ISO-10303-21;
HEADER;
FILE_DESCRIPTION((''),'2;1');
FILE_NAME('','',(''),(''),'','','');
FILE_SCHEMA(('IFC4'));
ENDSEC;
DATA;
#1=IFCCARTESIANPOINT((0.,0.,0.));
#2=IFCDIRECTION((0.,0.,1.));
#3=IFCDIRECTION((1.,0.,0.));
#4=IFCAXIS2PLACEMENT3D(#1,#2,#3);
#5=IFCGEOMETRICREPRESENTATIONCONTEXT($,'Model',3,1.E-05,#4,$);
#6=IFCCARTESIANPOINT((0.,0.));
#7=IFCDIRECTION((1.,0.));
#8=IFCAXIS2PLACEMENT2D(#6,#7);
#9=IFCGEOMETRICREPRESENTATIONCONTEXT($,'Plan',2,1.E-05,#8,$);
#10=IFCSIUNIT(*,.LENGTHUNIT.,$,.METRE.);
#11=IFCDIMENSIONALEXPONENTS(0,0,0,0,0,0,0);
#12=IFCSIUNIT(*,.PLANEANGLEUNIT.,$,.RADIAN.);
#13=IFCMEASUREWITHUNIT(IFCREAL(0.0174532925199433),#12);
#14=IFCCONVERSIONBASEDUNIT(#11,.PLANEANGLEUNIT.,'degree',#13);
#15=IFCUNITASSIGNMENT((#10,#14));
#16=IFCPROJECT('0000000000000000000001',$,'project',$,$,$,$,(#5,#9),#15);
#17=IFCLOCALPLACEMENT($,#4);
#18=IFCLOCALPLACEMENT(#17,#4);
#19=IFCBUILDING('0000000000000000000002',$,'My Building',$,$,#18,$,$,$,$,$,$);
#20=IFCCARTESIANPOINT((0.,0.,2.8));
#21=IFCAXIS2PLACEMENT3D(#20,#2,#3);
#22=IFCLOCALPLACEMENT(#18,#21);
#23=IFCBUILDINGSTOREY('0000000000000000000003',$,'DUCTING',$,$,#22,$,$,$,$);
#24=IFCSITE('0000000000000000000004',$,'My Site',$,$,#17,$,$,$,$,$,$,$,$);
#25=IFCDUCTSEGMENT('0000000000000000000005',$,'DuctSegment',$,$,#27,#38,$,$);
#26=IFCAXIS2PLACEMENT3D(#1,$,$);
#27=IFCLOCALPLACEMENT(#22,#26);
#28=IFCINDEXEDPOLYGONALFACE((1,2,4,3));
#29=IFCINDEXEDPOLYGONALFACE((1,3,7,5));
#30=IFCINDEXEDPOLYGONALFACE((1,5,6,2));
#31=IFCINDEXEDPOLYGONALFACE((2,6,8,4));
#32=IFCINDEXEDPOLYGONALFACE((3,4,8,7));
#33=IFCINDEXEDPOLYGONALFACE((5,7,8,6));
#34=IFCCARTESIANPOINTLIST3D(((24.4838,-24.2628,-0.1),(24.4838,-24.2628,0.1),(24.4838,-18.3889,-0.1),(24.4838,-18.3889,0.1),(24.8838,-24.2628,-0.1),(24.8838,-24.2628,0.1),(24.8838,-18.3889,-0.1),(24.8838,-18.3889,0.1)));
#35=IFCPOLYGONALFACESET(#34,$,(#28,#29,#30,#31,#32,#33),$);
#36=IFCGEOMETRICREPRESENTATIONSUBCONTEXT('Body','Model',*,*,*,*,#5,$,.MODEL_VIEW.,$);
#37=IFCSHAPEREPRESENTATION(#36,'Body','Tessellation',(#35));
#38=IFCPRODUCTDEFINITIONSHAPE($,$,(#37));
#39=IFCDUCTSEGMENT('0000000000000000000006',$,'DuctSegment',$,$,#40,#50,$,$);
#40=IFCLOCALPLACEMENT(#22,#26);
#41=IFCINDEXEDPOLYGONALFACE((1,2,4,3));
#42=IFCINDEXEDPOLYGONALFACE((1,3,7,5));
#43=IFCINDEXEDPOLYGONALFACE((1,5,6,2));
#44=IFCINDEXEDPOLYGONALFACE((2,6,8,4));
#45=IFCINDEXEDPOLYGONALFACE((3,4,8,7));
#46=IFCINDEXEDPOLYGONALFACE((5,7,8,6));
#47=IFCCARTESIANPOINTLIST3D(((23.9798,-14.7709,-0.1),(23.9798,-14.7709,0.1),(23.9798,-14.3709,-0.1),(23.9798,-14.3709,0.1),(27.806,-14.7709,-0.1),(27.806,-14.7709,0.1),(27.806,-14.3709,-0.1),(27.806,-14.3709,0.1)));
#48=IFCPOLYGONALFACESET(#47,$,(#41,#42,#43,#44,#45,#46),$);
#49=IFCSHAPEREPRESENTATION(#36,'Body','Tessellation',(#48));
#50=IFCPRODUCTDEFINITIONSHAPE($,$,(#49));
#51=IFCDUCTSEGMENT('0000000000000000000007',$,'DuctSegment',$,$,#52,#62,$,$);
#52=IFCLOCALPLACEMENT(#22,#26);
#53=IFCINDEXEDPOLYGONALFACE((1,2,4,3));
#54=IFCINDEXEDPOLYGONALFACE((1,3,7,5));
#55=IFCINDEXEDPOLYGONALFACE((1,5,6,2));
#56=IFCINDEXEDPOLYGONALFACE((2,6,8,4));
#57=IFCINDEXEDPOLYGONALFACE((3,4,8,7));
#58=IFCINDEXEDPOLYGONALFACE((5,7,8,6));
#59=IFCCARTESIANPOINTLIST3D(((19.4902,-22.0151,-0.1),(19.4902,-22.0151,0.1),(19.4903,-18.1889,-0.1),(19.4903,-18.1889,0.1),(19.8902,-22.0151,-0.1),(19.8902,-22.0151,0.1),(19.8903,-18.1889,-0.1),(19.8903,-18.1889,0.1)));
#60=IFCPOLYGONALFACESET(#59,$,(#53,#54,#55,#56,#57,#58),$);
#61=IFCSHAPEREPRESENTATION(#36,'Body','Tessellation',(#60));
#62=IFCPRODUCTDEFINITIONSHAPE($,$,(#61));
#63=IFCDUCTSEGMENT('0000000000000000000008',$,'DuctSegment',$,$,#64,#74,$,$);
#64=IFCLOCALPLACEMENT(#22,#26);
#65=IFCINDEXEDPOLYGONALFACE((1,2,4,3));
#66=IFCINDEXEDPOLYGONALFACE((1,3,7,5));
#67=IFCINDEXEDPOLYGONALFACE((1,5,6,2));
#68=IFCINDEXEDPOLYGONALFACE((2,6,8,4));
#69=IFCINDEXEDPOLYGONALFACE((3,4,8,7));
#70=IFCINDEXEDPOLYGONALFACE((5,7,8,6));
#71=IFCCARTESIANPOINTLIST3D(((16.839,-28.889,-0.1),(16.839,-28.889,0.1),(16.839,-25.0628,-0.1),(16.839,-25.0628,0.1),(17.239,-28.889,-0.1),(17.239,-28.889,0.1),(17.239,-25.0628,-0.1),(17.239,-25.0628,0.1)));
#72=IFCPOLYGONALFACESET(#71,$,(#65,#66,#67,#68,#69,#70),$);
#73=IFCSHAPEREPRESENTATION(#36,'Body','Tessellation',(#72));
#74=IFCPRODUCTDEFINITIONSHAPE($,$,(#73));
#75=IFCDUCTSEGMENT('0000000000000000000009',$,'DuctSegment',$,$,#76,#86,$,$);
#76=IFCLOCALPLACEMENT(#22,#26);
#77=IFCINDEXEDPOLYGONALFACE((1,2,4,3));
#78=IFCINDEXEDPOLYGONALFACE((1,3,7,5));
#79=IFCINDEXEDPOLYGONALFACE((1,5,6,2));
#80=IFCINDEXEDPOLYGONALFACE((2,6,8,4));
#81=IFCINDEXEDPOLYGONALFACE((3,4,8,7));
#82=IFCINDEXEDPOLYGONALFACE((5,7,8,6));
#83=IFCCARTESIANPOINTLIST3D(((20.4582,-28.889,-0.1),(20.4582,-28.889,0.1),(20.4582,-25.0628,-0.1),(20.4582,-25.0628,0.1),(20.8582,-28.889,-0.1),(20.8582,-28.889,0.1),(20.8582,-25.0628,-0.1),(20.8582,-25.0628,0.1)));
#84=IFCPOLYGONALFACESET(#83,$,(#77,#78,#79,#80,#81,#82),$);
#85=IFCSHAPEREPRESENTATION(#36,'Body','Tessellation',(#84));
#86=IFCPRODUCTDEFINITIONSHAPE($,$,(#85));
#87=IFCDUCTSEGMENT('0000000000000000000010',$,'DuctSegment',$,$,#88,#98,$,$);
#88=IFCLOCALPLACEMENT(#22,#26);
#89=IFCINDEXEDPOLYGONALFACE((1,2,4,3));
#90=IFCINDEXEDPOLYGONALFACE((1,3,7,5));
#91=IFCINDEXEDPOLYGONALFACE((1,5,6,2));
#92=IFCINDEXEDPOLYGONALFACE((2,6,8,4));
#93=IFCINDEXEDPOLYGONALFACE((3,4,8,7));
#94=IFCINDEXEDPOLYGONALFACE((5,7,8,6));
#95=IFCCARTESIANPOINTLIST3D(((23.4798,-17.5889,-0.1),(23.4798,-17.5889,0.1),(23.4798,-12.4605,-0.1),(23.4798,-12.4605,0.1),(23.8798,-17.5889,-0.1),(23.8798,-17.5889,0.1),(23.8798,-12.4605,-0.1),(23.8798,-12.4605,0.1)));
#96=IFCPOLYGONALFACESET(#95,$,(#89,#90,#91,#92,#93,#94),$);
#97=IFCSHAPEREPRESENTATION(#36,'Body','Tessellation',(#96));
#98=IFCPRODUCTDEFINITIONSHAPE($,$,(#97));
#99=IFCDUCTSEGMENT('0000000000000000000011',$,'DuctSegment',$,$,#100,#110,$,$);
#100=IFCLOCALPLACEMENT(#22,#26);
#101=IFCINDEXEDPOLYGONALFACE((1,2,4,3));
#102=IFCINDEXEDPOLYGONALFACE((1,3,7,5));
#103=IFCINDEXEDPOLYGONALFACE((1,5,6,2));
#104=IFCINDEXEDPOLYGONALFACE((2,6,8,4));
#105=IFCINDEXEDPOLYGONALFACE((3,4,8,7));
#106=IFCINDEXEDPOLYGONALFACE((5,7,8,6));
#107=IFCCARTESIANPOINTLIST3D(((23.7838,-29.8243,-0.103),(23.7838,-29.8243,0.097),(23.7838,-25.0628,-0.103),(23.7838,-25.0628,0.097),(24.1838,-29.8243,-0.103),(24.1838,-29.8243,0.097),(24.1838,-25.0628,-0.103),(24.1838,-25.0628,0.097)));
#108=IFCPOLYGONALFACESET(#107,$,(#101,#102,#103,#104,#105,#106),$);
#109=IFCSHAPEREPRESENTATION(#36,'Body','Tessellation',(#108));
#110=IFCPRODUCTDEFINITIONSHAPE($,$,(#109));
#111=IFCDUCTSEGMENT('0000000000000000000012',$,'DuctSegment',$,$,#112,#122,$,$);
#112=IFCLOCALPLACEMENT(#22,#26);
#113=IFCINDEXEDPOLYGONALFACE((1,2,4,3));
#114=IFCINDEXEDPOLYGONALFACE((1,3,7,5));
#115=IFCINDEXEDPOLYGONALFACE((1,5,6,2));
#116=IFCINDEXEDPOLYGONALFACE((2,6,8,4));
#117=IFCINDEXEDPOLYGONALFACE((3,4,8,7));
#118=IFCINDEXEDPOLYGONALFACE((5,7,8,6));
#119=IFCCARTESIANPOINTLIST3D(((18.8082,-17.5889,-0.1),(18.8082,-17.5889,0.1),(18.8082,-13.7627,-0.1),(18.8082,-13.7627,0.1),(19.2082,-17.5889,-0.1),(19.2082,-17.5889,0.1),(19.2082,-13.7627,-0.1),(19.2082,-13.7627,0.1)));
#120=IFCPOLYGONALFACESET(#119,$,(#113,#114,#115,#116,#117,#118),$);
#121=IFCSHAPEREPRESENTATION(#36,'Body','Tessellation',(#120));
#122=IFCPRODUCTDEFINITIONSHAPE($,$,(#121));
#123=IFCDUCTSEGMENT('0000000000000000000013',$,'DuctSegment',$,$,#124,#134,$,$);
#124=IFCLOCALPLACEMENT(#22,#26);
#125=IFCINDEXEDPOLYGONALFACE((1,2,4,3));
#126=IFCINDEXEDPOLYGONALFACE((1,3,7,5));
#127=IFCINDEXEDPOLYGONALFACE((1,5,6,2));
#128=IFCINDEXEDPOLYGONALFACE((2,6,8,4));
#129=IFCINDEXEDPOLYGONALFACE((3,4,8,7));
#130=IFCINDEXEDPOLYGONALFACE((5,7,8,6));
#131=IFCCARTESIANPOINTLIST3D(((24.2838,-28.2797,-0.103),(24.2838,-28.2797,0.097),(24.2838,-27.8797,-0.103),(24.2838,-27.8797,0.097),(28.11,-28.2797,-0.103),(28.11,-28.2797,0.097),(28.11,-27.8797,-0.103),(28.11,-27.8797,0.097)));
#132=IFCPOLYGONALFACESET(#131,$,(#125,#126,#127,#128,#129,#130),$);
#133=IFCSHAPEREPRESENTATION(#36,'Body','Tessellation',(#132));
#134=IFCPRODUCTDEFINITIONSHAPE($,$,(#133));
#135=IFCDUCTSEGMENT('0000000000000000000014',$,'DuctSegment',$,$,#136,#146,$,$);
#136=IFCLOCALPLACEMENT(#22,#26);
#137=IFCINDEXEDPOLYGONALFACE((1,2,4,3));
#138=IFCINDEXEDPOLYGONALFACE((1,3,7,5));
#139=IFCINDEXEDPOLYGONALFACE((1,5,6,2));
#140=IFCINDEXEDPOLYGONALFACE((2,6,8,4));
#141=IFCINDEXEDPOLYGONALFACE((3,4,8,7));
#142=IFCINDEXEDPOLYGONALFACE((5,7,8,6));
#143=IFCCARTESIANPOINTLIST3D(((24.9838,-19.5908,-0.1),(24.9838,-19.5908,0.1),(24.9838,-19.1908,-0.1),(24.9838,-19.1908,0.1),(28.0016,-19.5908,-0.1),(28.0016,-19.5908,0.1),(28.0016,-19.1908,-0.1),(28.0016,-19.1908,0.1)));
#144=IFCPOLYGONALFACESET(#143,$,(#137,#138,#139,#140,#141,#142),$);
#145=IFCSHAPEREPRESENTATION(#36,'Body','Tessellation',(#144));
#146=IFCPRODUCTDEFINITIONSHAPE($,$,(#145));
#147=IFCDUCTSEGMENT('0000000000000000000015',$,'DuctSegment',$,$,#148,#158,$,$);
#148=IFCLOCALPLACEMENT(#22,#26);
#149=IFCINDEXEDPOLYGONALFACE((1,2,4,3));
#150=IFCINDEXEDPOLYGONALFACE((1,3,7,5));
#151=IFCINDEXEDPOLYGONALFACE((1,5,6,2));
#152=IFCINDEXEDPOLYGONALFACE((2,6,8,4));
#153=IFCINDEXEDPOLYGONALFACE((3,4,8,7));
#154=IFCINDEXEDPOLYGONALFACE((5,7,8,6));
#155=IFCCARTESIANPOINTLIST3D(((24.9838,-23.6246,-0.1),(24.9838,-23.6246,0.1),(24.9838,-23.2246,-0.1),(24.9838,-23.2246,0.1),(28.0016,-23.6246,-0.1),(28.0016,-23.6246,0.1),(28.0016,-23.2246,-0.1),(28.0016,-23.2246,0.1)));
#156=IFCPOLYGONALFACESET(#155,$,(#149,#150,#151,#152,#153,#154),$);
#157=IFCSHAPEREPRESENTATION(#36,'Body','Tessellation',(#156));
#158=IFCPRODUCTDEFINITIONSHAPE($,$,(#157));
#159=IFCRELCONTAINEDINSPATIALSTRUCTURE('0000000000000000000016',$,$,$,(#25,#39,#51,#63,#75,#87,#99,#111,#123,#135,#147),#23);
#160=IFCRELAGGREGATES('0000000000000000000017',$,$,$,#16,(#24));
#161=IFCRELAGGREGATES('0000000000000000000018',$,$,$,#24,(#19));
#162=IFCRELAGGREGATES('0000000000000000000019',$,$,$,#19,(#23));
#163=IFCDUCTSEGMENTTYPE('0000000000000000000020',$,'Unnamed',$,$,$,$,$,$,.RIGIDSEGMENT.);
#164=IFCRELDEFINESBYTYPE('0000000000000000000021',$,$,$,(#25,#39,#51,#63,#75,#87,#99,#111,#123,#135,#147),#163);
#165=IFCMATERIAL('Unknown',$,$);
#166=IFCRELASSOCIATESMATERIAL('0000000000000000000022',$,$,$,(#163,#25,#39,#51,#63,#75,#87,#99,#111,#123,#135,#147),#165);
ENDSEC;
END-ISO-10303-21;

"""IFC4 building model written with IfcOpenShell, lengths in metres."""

from ifc_helpers import new_model, entity, si_unit, converted_unit, frame, origin_with_axes, origin_2d_with_axis, place, context, subcontext, project, spatial, rectangle, extrude, material, material_profile, profile_set, profile_usage, type_object, element, save


model = new_model("IFC4")

# Units and contexts
model_context = context("Model", 3, precision=1e-05, world=origin_with_axes())
plan_context = context("Plan", 2, precision=1e-05, world=origin_2d_with_axis())
body_context = subcontext(model_context, "Body", "Model", "MODEL_VIEW")
ifc_project = project(units=[si_unit("LENGTHUNIT", "METRE"), converted_unit("PLANEANGLEUNIT", "degree", entity("IfcReal", 0.0174532925199433), si_unit("PLANEANGLEUNIT", "RADIAN"), dimensions=[0, 0, 0, 0, 0, 0, 0])], contexts=[model_context, plan_context])

# Site, building, storey
site_placement = place(None, origin_with_axes())
site = spatial("IfcSite", under=ifc_project, at=site_placement, Name="My Site")
building_placement = place(site_placement, origin_with_axes())
building = spatial("IfcBuilding", under=site, at=building_placement, Name="My Building")
storey_placement = place(building_placement, frame((0.0, 0.0, 2.8), z_axis=(0.0, 0.0, 1.0), x_axis=(1.0, 0.0, 0.0)))
storey = spatial("IfcBuildingStorey", under=building, at=storey_placement, Name="DUCTING")

# Duct segments
ifc_material = material(Name="Unknown")
ifc_material_profile_1 = material_profile(ifc_material, rectangle(XDim=0.4, YDim=0.2))
ifc_profile_set_1 = profile_set([ifc_material_profile_1])
ifc_profile_usage_1 = profile_usage(ifc_profile_set_1, cardinal=5)
duct_segment_type = type_object("IfcDuctSegmentType", Name="Unnamed", PredefinedType="RIGIDSEGMENT", material=ifc_profile_set_1)
duct_segment_1_placement = place(storey_placement, frame((24.6838, -18.3889, 0.0), z_axis=(0.0, -1.0, 0.0), x_axis=(1.0, 0.0, 0.0)))
element("IfcDuctSegment", 1, at=duct_segment_1_placement, inside=storey, type_object=duct_segment_type, material=ifc_profile_usage_1, Name="DuctSegment", context=body_context, shape_type="SweptSolid", body=[
    extrude(rectangle(XDim=0.4, YDim=0.2), origin_with_axes(), (0.0, 0.0, 1.0), 5.8738),
])
ifc_profile_usage_2 = profile_usage(ifc_profile_set_1, cardinal=5)
duct_segment_2_placement = place(storey_placement, frame((23.9798, -14.5709, 0.0), z_axis=(1.0, 0.0, 0.0), x_axis=(0.0, 1.0, 0.0)))
element("IfcDuctSegment", 2, at=duct_segment_2_placement, inside=storey, type_object=duct_segment_type, material=ifc_profile_usage_2, Name="DuctSegment", context=body_context, shape_type="SweptSolid", body=[
    extrude(rectangle(XDim=0.4, YDim=0.2), origin_with_axes(), (0.0, 0.0, 1.0), 3.8262),
])
ifc_profile_usage_3 = profile_usage(ifc_profile_set_1, cardinal=5)
duct_segment_3_placement = place(storey_placement, frame((19.6903, -18.1889, 0.0), z_axis=(0.0, -1.0, 0.0), x_axis=(1.0, 0.0, 0.0)))
element("IfcDuctSegment", 3, at=duct_segment_3_placement, inside=storey, type_object=duct_segment_type, material=ifc_profile_usage_3, Name="DuctSegment", context=body_context, shape_type="SweptSolid", body=[
    extrude(rectangle(XDim=0.4, YDim=0.2), origin_with_axes(), (0.0, 0.0, 1.0), 3.8262),
])
ifc_profile_usage_4 = profile_usage(ifc_profile_set_1, cardinal=5)
duct_segment_4_placement = place(storey_placement, frame((17.039, -25.0628, 0.0), z_axis=(0.0, -1.0, 0.0), x_axis=(1.0, 0.0, 0.0)))
element("IfcDuctSegment", 4, at=duct_segment_4_placement, inside=storey, type_object=duct_segment_type, material=ifc_profile_usage_4, Name="DuctSegment", context=body_context, shape_type="SweptSolid", body=[
    extrude(rectangle(XDim=0.4, YDim=0.2), origin_with_axes(), (0.0, 0.0, 1.0), 3.8262),
])
ifc_profile_usage_5 = profile_usage(ifc_profile_set_1, cardinal=5)
duct_segment_5_placement = place(storey_placement, frame((20.6582, -25.0628, 0.0), z_axis=(0.0, -1.0, 0.0), x_axis=(1.0, 0.0, 0.0)))
element("IfcDuctSegment", 5, at=duct_segment_5_placement, inside=storey, type_object=duct_segment_type, material=ifc_profile_usage_5, Name="DuctSegment", context=body_context, shape_type="SweptSolid", body=[
    extrude(rectangle(XDim=0.4, YDim=0.2), origin_with_axes(), (0.0, 0.0, 1.0), 3.8262),
])
ifc_profile_usage_6 = profile_usage(ifc_profile_set_1, cardinal=5)
duct_segment_6_placement = place(storey_placement, frame((23.6798, -17.5889, 0.0), z_axis=(0.0, 1.0, 0.0), x_axis=(-1.0, 0.0, 0.0)))
element("IfcDuctSegment", 6, at=duct_segment_6_placement, inside=storey, type_object=duct_segment_type, material=ifc_profile_usage_6, Name="DuctSegment", context=body_context, shape_type="SweptSolid", body=[
    extrude(rectangle(XDim=0.4, YDim=0.2), origin_with_axes(), (0.0, 0.0, 1.0), 5.1284),
])
ifc_profile_usage_7 = profile_usage(ifc_profile_set_1, cardinal=5)
duct_segment_7_placement = place(storey_placement, frame((23.9838, -25.0628, -0.003), z_axis=(0.0, -1.0, 0.0), x_axis=(1.0, 0.0, 0.0)))
element("IfcDuctSegment", 7, at=duct_segment_7_placement, inside=storey, type_object=duct_segment_type, material=ifc_profile_usage_7, Name="DuctSegment", context=body_context, shape_type="SweptSolid", body=[
    extrude(rectangle(XDim=0.4, YDim=0.2), origin_with_axes(), (0.0, 0.0, 1.0), 4.7615),
])
ifc_profile_usage_8 = profile_usage(ifc_profile_set_1, cardinal=5)
duct_segment_8_placement = place(storey_placement, frame((19.0082, -17.5889, 0.0), z_axis=(0.0, 1.0, 0.0), x_axis=(-1.0, 0.0, 0.0)))
element("IfcDuctSegment", 8, at=duct_segment_8_placement, inside=storey, type_object=duct_segment_type, material=ifc_profile_usage_8, Name="DuctSegment", context=body_context, shape_type="SweptSolid", body=[
    extrude(rectangle(XDim=0.4, YDim=0.2), origin_with_axes(), (0.0, 0.0, 1.0), 3.8262),
])
ifc_profile_usage_9 = profile_usage(ifc_profile_set_1, cardinal=5)
duct_segment_9_placement = place(storey_placement, frame((24.2838, -28.0797, -0.003), z_axis=(1.0, 0.0, 0.0), x_axis=(0.0, 1.0, 0.0)))
element("IfcDuctSegment", 9, at=duct_segment_9_placement, inside=storey, type_object=duct_segment_type, material=ifc_profile_usage_9, Name="DuctSegment", context=body_context, shape_type="SweptSolid", body=[
    extrude(rectangle(XDim=0.4, YDim=0.2), origin_with_axes(), (0.0, 0.0, 1.0), 3.8262),
])
ifc_profile_usage_10 = profile_usage(ifc_profile_set_1, cardinal=5)
duct_segment_10_placement = place(storey_placement, frame((24.9838, -19.3908, 0.0), z_axis=(1.0, 0.0, 0.0), x_axis=(0.0, 1.0, 0.0)))
element("IfcDuctSegment", 10, at=duct_segment_10_placement, inside=storey, type_object=duct_segment_type, material=ifc_profile_usage_10, Name="DuctSegment", context=body_context, shape_type="SweptSolid", body=[
    extrude(rectangle(XDim=0.4, YDim=0.2), origin_with_axes(), (0.0, 0.0, 1.0), 3.0178),
])
ifc_profile_usage_11 = profile_usage(ifc_profile_set_1, cardinal=5)
duct_segment_11_placement = place(storey_placement, frame((24.9838, -23.4246, 0.0), z_axis=(1.0, 0.0, 0.0), x_axis=(0.0, 1.0, 0.0)))
element("IfcDuctSegment", 11, at=duct_segment_11_placement, inside=storey, type_object=duct_segment_type, material=ifc_profile_usage_11, Name="DuctSegment", context=body_context, shape_type="SweptSolid", body=[
    extrude(rectangle(XDim=0.4, YDim=0.2), origin_with_axes(), (0.0, 0.0, 1.0), 3.0178),
])

save(model, "model.ifc")
